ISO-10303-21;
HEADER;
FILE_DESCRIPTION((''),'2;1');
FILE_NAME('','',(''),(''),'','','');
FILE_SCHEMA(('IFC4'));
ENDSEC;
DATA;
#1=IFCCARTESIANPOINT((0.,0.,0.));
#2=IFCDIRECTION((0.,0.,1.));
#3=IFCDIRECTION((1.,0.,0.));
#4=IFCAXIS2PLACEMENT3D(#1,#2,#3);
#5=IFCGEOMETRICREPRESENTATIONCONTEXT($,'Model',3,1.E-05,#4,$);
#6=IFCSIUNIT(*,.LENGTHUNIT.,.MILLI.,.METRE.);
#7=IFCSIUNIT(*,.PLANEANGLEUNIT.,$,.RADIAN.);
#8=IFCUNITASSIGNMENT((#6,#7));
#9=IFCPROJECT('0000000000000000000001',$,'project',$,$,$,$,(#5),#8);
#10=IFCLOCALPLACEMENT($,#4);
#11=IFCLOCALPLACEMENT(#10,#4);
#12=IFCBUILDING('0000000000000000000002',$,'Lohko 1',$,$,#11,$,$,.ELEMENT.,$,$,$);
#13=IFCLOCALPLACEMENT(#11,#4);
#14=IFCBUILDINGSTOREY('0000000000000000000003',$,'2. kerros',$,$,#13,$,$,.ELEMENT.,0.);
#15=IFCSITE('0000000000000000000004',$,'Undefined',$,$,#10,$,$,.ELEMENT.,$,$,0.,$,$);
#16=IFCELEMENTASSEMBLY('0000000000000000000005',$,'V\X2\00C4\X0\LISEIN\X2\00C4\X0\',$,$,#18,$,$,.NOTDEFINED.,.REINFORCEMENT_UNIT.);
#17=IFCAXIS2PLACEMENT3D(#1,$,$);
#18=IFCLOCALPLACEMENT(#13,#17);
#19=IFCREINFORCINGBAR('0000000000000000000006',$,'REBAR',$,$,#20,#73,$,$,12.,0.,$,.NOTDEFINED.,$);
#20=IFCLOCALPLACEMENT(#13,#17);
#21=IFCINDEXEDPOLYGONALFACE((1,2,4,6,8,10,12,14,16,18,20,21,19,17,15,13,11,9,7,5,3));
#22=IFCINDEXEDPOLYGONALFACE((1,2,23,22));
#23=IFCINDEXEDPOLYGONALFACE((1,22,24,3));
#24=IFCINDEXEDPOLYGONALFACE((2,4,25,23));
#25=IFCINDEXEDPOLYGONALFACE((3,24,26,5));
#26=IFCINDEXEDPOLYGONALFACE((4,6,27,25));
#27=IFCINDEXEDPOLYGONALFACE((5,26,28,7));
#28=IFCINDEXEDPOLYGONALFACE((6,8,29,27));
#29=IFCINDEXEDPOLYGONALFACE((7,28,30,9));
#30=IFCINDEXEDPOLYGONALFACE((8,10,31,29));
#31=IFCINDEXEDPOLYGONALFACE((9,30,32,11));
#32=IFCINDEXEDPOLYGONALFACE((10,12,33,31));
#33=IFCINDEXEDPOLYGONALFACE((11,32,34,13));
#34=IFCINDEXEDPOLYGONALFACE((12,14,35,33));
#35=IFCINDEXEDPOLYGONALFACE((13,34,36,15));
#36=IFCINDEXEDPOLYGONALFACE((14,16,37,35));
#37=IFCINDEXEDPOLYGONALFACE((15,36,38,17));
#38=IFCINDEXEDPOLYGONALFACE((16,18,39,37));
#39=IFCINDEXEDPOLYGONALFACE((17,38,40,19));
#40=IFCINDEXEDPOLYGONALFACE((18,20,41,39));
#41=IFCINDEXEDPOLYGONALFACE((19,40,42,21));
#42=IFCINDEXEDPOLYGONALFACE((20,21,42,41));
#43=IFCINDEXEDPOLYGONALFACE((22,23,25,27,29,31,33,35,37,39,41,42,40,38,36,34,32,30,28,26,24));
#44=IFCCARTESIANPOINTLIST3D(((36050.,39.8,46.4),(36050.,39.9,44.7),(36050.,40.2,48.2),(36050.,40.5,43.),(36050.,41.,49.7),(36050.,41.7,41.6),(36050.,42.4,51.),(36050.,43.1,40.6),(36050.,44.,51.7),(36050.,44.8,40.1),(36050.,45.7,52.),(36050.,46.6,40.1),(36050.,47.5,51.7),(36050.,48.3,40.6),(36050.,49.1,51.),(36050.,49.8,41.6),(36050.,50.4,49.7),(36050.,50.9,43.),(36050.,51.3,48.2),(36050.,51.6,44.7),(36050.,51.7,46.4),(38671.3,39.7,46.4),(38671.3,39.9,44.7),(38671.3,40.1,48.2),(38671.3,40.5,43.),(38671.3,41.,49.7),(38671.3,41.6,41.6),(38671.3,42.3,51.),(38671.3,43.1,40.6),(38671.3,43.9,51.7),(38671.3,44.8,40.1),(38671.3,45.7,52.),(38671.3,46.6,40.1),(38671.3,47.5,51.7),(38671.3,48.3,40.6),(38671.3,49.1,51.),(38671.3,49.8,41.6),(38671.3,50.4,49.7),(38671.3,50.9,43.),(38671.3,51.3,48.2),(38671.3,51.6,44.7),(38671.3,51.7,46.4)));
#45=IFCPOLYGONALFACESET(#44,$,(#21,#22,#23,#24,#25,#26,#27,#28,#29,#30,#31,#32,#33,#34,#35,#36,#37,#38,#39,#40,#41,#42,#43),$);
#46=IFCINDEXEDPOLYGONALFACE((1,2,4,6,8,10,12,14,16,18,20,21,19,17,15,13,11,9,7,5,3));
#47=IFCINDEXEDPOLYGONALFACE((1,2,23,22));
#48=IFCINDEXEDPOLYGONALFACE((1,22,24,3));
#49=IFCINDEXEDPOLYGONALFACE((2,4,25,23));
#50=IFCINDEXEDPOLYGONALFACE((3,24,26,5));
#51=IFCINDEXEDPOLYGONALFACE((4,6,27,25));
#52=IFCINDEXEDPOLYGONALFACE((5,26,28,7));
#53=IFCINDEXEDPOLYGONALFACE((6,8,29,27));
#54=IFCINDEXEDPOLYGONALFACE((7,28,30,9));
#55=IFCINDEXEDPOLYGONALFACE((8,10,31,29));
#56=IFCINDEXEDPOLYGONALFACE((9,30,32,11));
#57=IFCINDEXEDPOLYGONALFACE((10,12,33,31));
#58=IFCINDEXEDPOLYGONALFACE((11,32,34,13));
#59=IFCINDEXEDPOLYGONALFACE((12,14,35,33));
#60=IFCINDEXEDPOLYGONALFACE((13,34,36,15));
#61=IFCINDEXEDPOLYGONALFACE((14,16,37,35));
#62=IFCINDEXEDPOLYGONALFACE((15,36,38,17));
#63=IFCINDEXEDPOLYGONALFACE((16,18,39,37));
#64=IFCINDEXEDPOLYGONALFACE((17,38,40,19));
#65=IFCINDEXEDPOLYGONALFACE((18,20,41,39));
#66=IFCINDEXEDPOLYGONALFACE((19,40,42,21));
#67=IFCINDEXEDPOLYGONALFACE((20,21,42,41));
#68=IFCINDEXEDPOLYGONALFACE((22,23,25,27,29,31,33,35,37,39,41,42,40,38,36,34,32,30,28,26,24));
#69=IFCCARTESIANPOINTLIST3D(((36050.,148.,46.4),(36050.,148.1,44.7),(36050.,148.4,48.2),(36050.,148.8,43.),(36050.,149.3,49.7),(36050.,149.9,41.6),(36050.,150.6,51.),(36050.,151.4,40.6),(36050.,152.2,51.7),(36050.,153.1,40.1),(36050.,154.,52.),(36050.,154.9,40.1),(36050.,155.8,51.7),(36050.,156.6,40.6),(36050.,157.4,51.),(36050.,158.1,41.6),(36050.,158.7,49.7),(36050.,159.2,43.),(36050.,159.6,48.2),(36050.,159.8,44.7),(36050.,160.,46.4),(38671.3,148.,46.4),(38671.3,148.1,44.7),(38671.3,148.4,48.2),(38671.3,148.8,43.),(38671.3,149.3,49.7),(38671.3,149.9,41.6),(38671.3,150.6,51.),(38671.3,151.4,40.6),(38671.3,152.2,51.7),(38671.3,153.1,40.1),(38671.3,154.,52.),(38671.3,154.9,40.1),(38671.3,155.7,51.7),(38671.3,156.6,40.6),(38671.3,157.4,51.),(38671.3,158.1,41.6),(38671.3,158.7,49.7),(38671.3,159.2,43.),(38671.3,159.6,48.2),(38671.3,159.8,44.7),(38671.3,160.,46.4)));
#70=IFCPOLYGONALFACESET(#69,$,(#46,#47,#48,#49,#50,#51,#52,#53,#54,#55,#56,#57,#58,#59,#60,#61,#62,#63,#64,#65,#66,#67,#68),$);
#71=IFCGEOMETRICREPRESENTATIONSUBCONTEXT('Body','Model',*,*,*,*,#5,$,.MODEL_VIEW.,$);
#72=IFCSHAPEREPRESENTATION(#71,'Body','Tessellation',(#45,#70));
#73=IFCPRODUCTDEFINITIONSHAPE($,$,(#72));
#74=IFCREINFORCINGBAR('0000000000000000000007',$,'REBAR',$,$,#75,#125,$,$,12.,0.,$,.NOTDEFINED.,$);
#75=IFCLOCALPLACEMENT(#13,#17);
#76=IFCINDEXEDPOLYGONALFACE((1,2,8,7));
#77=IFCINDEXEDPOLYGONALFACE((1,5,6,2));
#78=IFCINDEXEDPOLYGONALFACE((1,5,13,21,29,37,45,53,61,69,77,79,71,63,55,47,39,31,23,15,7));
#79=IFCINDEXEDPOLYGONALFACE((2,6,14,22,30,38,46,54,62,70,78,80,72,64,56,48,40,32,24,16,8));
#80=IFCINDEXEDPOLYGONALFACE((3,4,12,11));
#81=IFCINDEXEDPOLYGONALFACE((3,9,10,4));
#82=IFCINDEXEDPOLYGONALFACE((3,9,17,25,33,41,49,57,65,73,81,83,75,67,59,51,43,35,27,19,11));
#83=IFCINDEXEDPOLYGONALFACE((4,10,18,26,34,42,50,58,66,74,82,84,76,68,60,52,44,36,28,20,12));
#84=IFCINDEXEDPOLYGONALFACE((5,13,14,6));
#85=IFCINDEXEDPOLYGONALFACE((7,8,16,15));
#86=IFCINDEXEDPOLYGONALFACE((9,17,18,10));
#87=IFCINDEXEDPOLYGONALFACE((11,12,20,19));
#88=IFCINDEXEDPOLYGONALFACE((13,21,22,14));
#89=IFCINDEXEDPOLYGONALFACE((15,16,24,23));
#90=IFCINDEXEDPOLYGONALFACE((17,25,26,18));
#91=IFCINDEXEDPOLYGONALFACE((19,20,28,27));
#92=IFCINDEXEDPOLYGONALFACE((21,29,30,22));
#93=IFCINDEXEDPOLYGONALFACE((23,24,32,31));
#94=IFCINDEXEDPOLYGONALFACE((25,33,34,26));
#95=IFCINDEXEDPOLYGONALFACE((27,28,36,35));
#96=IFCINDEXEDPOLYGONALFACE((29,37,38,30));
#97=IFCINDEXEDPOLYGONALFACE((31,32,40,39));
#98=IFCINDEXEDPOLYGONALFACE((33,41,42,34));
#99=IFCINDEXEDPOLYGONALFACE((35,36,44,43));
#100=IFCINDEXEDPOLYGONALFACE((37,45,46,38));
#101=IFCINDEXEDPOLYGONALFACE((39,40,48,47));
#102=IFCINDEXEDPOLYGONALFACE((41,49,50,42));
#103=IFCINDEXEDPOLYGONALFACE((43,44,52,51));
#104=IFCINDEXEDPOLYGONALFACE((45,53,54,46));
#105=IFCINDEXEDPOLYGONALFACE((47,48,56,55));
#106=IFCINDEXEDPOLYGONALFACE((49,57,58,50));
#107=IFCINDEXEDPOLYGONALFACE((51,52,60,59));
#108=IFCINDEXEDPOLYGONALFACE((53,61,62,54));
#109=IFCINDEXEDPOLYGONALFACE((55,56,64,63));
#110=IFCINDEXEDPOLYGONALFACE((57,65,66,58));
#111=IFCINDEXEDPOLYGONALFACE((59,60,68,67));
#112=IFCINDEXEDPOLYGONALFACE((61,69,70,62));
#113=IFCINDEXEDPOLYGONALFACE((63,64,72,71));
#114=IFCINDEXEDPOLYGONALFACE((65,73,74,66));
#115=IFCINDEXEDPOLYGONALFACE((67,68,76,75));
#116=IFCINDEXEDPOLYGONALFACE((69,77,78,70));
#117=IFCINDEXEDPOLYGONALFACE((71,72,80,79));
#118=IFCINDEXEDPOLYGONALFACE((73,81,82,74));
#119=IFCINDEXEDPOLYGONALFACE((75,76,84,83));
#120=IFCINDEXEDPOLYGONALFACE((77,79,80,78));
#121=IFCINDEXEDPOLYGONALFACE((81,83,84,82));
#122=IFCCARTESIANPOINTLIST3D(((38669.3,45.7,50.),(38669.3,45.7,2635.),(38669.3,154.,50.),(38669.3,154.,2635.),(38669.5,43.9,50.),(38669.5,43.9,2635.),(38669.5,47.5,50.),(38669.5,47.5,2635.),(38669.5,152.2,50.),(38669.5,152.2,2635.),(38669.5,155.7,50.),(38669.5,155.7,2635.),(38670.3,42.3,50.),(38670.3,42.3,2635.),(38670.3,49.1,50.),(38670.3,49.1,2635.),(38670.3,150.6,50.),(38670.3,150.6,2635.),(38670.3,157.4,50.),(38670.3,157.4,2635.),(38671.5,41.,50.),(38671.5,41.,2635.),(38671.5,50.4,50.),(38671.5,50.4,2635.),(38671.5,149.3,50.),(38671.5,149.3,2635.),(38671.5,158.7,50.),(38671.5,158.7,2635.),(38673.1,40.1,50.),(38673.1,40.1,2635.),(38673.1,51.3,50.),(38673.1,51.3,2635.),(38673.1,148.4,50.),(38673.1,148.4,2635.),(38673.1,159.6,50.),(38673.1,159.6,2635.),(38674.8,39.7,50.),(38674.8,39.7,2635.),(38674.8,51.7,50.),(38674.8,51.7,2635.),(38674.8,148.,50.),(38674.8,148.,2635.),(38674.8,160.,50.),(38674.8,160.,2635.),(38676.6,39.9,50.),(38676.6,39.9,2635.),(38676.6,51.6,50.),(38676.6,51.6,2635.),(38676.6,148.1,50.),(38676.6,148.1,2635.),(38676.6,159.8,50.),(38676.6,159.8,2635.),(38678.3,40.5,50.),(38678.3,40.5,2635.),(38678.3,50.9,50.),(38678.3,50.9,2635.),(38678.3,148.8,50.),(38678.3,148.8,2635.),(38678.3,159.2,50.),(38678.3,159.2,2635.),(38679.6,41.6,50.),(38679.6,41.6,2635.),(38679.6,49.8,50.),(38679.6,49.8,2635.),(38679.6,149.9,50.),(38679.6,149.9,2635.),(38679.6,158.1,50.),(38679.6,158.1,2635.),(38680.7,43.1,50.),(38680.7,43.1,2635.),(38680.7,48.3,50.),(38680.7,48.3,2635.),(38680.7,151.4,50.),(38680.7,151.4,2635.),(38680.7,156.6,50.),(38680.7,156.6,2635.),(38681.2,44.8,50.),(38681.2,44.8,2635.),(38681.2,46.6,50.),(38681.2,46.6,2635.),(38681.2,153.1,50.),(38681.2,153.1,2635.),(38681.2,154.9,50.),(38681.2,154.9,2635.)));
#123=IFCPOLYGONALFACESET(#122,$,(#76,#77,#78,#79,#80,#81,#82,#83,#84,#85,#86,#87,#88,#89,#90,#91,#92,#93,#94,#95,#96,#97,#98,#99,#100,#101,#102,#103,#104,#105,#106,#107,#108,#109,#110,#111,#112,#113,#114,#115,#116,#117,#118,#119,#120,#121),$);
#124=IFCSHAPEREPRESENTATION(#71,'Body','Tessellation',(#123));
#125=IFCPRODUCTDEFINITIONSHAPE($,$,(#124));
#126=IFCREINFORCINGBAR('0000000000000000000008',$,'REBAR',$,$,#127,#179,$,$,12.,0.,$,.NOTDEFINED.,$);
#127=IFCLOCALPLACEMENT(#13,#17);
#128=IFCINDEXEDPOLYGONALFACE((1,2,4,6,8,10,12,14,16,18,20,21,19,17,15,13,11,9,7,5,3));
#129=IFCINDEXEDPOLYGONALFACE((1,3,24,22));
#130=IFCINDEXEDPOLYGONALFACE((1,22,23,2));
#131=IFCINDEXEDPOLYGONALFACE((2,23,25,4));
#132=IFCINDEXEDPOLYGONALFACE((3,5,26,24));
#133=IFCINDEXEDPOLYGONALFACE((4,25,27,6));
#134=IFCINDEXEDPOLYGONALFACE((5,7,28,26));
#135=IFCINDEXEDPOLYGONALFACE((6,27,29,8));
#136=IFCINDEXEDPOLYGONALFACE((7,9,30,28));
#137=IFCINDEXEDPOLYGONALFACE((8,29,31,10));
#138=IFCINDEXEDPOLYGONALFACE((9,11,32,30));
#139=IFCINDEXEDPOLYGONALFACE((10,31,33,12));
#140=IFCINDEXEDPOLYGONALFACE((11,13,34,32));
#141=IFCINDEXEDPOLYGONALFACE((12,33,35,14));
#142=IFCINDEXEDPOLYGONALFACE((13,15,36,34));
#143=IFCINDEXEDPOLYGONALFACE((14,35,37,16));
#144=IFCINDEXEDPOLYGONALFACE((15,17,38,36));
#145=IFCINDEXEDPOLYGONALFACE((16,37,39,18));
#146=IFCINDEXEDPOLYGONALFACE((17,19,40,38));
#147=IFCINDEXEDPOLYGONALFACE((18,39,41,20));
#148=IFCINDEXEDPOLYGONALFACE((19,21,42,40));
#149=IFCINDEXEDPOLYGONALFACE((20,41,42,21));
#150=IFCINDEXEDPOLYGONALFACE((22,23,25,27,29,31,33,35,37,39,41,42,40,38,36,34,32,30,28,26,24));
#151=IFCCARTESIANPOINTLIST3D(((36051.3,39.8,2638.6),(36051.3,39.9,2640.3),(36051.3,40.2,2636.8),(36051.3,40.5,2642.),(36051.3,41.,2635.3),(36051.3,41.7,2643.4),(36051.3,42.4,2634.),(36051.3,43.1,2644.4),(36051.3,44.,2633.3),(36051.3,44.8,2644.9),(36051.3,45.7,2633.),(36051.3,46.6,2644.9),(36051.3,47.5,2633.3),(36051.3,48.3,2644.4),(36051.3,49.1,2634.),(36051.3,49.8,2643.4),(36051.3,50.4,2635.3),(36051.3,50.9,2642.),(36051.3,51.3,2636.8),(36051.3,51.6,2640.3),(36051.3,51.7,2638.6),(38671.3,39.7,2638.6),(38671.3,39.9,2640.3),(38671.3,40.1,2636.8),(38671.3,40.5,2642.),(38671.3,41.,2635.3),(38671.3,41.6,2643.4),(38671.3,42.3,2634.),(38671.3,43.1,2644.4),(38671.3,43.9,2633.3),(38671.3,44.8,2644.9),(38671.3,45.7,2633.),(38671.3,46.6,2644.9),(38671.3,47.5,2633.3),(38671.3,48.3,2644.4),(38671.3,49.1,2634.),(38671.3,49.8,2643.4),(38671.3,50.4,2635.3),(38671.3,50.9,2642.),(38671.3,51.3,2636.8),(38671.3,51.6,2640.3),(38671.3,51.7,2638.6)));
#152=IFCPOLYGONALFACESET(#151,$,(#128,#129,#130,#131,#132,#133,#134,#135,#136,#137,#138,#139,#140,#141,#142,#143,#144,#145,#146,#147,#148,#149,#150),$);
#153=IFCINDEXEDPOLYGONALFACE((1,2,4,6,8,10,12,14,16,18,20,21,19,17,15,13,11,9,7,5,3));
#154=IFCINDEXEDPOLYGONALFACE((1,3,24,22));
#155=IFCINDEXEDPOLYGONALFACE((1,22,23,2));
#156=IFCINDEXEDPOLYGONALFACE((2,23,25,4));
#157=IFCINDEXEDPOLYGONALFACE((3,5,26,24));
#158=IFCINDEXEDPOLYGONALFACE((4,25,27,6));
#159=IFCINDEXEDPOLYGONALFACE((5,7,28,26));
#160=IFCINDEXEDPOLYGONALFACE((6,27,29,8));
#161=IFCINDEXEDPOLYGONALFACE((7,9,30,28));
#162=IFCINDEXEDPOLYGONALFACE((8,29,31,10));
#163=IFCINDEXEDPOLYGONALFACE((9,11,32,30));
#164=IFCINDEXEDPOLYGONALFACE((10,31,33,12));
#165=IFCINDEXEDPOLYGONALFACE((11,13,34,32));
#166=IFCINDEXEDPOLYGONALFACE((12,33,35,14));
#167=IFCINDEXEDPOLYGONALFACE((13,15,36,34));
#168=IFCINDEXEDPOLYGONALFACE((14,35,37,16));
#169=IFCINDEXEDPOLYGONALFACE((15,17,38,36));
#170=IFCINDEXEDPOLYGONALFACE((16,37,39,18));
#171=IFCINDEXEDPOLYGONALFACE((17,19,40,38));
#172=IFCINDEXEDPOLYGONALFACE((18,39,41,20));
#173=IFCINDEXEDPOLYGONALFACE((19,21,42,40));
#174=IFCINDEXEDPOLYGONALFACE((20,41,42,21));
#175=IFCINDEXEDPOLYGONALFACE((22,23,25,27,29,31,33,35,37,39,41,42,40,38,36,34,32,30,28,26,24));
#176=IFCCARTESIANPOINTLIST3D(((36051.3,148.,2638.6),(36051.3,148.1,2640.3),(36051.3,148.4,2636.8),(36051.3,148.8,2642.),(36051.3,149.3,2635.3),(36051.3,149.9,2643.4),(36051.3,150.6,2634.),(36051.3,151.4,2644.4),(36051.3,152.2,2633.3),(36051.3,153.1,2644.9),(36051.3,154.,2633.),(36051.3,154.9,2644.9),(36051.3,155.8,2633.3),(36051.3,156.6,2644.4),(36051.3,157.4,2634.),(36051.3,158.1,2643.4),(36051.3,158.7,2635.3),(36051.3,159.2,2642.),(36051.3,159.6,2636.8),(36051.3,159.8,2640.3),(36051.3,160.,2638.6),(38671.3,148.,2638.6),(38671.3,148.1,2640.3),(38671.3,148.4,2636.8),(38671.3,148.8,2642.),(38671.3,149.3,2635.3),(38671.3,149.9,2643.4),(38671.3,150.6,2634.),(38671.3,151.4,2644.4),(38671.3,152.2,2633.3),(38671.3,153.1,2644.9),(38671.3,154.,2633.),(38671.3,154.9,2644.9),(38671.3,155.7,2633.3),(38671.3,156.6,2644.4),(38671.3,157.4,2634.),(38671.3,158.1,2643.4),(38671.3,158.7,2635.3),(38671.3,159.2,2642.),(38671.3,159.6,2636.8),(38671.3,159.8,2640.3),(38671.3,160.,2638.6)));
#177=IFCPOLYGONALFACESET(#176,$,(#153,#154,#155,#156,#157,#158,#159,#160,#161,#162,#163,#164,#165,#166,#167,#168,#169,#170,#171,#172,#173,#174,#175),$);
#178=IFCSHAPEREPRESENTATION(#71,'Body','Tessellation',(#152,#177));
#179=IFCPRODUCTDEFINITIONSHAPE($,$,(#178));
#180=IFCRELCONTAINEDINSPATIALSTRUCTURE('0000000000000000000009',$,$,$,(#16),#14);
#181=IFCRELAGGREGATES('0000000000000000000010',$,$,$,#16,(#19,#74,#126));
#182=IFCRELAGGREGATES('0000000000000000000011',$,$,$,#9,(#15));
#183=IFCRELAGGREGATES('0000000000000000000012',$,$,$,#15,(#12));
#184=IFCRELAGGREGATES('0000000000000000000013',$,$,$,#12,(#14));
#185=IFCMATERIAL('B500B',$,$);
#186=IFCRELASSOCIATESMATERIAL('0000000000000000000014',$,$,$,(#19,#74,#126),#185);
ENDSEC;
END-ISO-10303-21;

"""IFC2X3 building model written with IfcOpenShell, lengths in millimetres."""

from ifc_helpers import new_model, entity, si_unit, frame, origin_with_axes, place, context, subcontext, project, spatial, source, transform, mapped, material, element, aggregate, save


model = new_model("IFC2X3")

# Units and contexts
model_context = context("Model", 3, precision=1e-05, world=origin_with_axes())
body_context = subcontext(model_context, "Body", "Model", "MODEL_VIEW")
ifc_project = project(units=[si_unit("LENGTHUNIT", "METRE", prefix="MILLI"), si_unit("PLANEANGLEUNIT", "RADIAN")], contexts=[model_context])

# Site, building, storey
site_placement = place(None, origin_with_axes())
site = spatial("IfcSite", under=ifc_project, at=site_placement, Name="Undefined", CompositionType="ELEMENT", RefElevation=0.0)
building_placement = place(site_placement, origin_with_axes())
building = spatial("IfcBuilding", under=site, at=building_placement, Name="Lohko 1", CompositionType="ELEMENT")
storey_placement = place(building_placement, origin_with_axes())
storey = spatial("IfcBuildingStorey", under=building, at=storey_placement, Name="2. kerros", CompositionType="ELEMENT", Elevation=0.0)

# Element assembly, reinforcing bars
assembly_placement = place(storey_placement, origin_with_axes())
assembly = element("IfcElementAssembly", 1, at=assembly_placement, inside=storey, Name="VÄLISEINÄ", AssemblyPlace="NOTDEFINED", PredefinedType="REINFORCEMENT_UNIT")
ifc_material = material(Name="B500B")
shared_shape_1 = source(origin_with_axes(), body_context, "Body", "AdvancedSweptSolid", [
    entity("IfcSweptDiskSolid", entity("IfcTrimmedCurve", entity("IfcLine", entity("IfcCartesianPoint", [0.0, 0.0, 0.0]), entity("IfcVector", entity("IfcDirection", [1.0, 0.0, 0.0]), 1.0)), [entity("IfcParameterValue", 0.0)], [entity("IfcParameterValue", 2621.2505)], True, "PARAMETER"), 6.0, None, 0.0, 2621.3),
])
shared_shape_2 = source(origin_with_axes(), body_context, "Body", "AdvancedSweptSolid", [
    entity("IfcSweptDiskSolid", entity("IfcTrimmedCurve", entity("IfcLine", entity("IfcCartesianPoint", [0.0, 0.0, 0.0]), entity("IfcVector", entity("IfcDirection", [1.0, 0.0, 0.0]), 1.0)), [entity("IfcParameterValue", 0.0)], [entity("IfcParameterValue", 2621.2505)], True, "PARAMETER"), 6.0, None, 0.0, 2621.3),
])
reinforcing_bar_1_placement = place(assembly_placement, frame((36000.0, -0.3, 0.0), z_axis=(0.0, 0.0, 1.0), x_axis=(1.0, -0.000007, 0.0)))
reinforcing_bar_1 = element("IfcReinforcingBar", 2, at=reinforcing_bar_1_placement, material=ifc_material, Name="REBAR", BarRole="NOTDEFINED", CrossSectionArea=0.0, NominalDiameter=12.0, context=body_context, shape_type="MappedRepresentation", body=[
    mapped(shared_shape_1, transform((50.0, 46.0, 46.0))),
    mapped(shared_shape_2, transform((50.0, 154.3, 46.0))),
])
shared_shape_3 = source(origin_with_axes(), body_context, "Body", "AdvancedSweptSolid", [
    entity("IfcSweptDiskSolid", entity("IfcTrimmedCurve", entity("IfcLine", entity("IfcCartesianPoint", [0.0, 0.0, 0.0]), entity("IfcVector", entity("IfcDirection", [1.0, 0.0, 0.0]), 1.0)), [entity("IfcParameterValue", 0.0)], [entity("IfcParameterValue", 2585.0)], True, "PARAMETER"), 6.0, None, 0.0, 2585.0),
])
shared_shape_4 = source(origin_with_axes(), body_context, "Body", "AdvancedSweptSolid", [
    entity("IfcSweptDiskSolid", entity("IfcTrimmedCurve", entity("IfcLine", entity("IfcCartesianPoint", [0.0, 0.0, 0.0]), entity("IfcVector", entity("IfcDirection", [1.0, 0.0, 0.0]), 1.0)), [entity("IfcParameterValue", 0.0)], [entity("IfcParameterValue", 2585.0)], True, "PARAMETER"), 6.0, None, 0.0, 2585.0),
])
reinforcing_bar_2_placement = place(assembly_placement, frame((38721.3, -0.3, 0.0), z_axis=(-1.0, 0.000007, 0.0), x_axis=(0.0, 0.0, 1.0)))
reinforcing_bar_2 = element("IfcReinforcingBar", 3, at=reinforcing_bar_2_placement, material=ifc_material, Name="REBAR", BarRole="NOTDEFINED", CrossSectionArea=0.0, NominalDiameter=12.0, context=body_context, shape_type="MappedRepresentation", body=[
    mapped(shared_shape_3, transform((50.0, 46.0, 46.0))),
    mapped(shared_shape_4, transform((50.0, 154.3, 46.0))),
])
shared_shape_5 = source(origin_with_axes(), body_context, "Body", "AdvancedSweptSolid", [
    entity("IfcSweptDiskSolid", entity("IfcTrimmedCurve", entity("IfcLine", entity("IfcCartesianPoint", [0.0, 0.0, 0.0]), entity("IfcVector", entity("IfcDirection", [1.0, 0.0, 0.0]), 1.0)), [entity("IfcParameterValue", 0.0)], [entity("IfcParameterValue", 2620.0)], True, "PARAMETER"), 6.0, None, 0.0, 2620.0),
])
shared_shape_6 = source(origin_with_axes(), body_context, "Body", "AdvancedSweptSolid", [
    entity("IfcSweptDiskSolid", entity("IfcTrimmedCurve", entity("IfcLine", entity("IfcCartesianPoint", [0.0, 0.0, 0.0]), entity("IfcVector", entity("IfcDirection", [1.0, 0.0, 0.0]), 1.0)), [entity("IfcParameterValue", 0.0)], [entity("IfcParameterValue", 2620.0)], True, "PARAMETER"), 6.0, None, 0.0, 2620.0),
])
reinforcing_bar_3_placement = place(assembly_placement, frame((38721.3, -0.3, 2685.0), z_axis=(0.0, 0.0, -1.0), x_axis=(-1.0, 0.000007, 0.0)))
reinforcing_bar_3 = element("IfcReinforcingBar", 4, at=reinforcing_bar_3_placement, material=ifc_material, Name="REBAR", BarRole="NOTDEFINED", CrossSectionArea=0.0, NominalDiameter=12.0, context=body_context, shape_type="MappedRepresentation", body=[
    mapped(shared_shape_5, transform((50.0, 46.0, 46.0))),
    mapped(shared_shape_6, transform((50.0, 154.3, 46.0))),
])
aggregate(assembly, [reinforcing_bar_1, reinforcing_bar_2, reinforcing_bar_3])

save(model, "model.ifc")
